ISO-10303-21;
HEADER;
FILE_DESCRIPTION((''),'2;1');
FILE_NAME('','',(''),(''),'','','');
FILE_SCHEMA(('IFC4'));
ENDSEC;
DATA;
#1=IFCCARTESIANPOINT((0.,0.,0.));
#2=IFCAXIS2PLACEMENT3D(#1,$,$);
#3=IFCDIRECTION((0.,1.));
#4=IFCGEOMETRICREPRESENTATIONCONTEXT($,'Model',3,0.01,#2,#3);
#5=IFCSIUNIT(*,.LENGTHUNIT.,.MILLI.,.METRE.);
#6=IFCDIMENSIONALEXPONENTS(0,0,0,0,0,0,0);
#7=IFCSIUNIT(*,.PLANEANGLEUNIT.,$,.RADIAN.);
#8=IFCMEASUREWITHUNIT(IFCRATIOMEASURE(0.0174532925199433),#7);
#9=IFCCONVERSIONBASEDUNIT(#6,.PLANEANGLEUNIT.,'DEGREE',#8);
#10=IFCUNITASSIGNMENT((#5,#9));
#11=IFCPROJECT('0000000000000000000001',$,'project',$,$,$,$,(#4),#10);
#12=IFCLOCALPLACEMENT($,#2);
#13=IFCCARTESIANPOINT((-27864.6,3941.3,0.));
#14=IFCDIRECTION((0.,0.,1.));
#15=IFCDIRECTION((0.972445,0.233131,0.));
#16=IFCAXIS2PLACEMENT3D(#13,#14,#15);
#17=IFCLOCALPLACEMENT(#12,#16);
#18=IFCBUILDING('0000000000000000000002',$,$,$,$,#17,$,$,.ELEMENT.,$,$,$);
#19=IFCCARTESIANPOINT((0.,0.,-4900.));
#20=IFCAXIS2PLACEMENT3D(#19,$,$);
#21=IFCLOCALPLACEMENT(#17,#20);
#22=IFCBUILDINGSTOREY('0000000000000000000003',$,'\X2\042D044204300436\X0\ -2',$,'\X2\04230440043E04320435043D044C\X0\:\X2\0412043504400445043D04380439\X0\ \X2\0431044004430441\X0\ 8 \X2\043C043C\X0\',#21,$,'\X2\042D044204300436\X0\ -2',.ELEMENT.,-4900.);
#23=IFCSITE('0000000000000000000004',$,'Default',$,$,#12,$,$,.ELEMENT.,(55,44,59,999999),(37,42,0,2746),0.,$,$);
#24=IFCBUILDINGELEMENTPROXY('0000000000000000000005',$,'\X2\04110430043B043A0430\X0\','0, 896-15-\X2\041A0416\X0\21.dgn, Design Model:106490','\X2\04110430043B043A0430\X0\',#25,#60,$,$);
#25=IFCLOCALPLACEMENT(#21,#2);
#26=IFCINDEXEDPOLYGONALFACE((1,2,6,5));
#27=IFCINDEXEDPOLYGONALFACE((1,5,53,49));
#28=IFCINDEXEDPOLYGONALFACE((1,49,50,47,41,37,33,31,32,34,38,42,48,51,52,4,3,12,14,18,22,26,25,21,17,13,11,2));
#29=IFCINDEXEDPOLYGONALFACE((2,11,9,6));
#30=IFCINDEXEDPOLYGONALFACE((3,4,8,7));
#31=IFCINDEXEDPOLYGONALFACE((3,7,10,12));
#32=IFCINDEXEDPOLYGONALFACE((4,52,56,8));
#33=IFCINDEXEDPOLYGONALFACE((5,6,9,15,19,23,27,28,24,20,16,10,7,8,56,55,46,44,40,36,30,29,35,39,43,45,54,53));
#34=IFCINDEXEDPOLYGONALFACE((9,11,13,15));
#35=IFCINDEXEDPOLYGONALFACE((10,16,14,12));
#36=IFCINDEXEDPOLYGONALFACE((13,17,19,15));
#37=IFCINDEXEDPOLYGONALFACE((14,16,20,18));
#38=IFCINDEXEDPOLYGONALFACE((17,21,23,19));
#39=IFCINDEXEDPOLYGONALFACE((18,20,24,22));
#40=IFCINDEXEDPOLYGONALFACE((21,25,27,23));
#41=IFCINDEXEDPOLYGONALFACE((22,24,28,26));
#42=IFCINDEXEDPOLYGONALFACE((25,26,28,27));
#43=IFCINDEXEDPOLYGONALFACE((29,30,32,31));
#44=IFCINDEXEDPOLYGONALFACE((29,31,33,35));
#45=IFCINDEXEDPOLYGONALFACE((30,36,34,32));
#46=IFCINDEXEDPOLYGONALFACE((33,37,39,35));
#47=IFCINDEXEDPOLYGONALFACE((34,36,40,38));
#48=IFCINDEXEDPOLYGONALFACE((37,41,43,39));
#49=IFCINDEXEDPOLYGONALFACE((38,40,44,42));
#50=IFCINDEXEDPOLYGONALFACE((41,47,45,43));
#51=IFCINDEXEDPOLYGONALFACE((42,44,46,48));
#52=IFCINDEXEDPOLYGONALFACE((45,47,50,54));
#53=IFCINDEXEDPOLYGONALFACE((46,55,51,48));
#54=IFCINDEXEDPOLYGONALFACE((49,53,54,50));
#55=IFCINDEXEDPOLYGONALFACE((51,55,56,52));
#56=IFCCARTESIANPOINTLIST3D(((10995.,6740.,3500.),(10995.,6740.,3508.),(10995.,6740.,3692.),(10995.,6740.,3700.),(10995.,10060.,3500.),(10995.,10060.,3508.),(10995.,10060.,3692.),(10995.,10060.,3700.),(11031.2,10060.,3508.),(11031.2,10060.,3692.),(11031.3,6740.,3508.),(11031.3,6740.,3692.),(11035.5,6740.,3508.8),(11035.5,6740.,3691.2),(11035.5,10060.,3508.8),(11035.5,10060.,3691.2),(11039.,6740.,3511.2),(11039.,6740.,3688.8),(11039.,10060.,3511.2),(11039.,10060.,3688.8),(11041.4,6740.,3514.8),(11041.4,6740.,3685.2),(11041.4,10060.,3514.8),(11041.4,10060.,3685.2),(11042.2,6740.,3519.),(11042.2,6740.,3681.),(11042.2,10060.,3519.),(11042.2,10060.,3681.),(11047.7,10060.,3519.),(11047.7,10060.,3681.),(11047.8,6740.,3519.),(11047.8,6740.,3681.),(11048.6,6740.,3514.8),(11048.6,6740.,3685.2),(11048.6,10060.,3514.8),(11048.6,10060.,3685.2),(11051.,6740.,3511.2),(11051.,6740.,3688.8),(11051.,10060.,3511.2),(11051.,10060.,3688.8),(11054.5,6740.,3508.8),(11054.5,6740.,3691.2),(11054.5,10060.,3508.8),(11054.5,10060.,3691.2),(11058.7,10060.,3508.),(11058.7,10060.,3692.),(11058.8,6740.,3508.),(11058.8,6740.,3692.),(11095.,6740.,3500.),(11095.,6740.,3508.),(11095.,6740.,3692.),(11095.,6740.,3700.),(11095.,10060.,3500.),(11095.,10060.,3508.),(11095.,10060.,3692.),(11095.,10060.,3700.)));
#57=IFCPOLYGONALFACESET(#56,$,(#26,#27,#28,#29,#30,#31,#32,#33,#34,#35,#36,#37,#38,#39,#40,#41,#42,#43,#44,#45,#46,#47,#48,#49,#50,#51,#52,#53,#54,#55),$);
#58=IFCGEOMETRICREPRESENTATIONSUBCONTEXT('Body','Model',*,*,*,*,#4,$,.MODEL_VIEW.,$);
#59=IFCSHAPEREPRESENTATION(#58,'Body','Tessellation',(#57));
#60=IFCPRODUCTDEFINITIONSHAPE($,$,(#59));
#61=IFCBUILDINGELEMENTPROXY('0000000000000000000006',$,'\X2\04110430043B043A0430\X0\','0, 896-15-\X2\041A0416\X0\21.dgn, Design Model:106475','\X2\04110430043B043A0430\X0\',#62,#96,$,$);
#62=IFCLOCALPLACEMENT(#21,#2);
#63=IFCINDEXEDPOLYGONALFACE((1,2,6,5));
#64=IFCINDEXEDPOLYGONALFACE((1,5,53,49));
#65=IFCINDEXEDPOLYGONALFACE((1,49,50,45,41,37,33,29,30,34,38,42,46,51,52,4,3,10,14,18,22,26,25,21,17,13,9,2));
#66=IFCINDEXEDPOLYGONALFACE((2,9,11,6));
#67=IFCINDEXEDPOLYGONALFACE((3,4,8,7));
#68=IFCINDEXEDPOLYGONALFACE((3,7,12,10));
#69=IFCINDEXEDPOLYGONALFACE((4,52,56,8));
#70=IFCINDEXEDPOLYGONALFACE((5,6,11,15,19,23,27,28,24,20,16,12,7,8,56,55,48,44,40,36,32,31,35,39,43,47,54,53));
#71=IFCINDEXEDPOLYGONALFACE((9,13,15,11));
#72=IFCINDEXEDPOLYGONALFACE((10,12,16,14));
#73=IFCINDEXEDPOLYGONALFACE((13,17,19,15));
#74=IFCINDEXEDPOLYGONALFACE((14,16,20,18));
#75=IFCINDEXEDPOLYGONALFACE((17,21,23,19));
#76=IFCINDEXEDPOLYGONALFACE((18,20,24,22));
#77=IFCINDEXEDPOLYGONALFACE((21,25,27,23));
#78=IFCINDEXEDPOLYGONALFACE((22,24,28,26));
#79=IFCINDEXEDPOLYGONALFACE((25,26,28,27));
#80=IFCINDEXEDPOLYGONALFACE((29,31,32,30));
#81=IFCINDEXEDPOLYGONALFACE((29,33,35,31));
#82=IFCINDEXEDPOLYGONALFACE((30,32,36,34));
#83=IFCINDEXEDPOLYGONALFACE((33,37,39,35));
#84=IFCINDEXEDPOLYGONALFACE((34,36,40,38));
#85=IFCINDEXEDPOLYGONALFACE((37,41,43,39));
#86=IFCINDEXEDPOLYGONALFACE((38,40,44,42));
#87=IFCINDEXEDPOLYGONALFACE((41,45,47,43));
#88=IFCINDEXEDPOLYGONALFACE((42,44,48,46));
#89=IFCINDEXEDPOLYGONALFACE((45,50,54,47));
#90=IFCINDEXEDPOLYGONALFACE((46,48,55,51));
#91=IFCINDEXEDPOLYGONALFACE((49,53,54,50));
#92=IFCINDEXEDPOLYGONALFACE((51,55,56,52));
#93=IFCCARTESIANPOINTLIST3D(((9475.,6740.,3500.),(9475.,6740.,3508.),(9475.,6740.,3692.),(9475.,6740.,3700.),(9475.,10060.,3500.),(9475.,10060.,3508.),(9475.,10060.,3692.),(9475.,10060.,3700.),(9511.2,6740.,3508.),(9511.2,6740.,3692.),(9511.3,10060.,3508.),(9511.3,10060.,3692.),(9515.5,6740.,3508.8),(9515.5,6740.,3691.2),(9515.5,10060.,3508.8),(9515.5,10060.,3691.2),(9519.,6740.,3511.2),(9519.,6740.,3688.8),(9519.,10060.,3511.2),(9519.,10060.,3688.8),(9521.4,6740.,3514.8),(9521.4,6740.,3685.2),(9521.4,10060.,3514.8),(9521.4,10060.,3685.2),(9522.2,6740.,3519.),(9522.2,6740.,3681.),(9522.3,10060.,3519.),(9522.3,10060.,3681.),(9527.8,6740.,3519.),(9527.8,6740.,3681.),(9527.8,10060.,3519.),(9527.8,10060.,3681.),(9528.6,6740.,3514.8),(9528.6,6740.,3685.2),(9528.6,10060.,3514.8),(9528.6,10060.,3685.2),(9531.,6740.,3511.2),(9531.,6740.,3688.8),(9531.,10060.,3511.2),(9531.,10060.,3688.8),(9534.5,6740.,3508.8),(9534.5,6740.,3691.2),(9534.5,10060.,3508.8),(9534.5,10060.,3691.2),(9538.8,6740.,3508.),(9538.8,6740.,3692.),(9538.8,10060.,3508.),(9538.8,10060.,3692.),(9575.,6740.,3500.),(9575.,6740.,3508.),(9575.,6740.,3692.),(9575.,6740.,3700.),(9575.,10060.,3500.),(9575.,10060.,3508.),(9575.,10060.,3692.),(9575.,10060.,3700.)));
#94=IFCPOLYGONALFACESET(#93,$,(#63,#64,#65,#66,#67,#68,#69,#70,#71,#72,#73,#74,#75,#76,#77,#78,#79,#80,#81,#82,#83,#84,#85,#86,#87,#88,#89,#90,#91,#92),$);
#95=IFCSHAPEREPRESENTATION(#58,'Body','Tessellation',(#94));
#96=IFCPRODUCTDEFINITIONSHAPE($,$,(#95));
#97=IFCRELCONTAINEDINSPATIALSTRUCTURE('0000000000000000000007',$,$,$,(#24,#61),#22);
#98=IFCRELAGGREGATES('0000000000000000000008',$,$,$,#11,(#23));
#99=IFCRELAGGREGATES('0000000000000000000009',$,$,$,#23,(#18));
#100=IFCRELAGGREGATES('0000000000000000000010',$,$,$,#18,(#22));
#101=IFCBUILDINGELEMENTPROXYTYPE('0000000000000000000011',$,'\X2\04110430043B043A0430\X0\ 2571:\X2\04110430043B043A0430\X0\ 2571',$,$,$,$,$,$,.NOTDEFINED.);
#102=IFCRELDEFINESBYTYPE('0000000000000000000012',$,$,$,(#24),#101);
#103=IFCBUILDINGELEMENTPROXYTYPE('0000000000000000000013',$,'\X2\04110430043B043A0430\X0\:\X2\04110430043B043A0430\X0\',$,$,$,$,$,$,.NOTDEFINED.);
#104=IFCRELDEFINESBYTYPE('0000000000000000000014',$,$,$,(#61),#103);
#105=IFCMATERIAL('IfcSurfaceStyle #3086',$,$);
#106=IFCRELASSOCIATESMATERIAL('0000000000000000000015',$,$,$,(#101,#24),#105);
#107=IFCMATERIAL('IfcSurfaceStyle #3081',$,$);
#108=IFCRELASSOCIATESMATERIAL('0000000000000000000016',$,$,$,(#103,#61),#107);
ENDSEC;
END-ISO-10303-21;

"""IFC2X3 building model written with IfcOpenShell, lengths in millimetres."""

from ifc_helpers import new_model, entity, si_unit, converted_unit, direction, frame, origin, place, context, subcontext, project, spatial, polyline, outline, extrude, source, transform, mapped, material, type_object, type_shapes, element, save


model = new_model("IFC2X3")

# Units and contexts
model_context = context("Model", 3, precision=0.01, world=origin(), true_north=direction((0.0, 1.0)))
body_context = subcontext(model_context, "Body", "Model", "MODEL_VIEW")
ifc_project = project(units=[si_unit("LENGTHUNIT", "METRE", prefix="MILLI"), converted_unit("PLANEANGLEUNIT", "DEGREE", entity("IfcRatioMeasure", 0.0174532925199433), si_unit("PLANEANGLEUNIT", "RADIAN"), dimensions=[0, 0, 0, 0, 0, 0, 0])], contexts=[model_context])

# Site, building, storey
site_placement = place(None, origin())
site = spatial("IfcSite", under=ifc_project, at=site_placement, Name="Default", CompositionType="ELEMENT", RefLatitude=(55, 44, 59, 999999), RefLongitude=(37, 42, 0, 2746), RefElevation=0.0)
building_placement = place(site_placement, frame((-27864.6, 3941.3, 0.0), z_axis=(0.0, 0.0, 1.0), x_axis=(0.972445, 0.233131, 0.0)))
building = spatial("IfcBuilding", under=site, at=building_placement, CompositionType="ELEMENT")
storey_placement = place(building_placement, frame((0.0, 0.0, -4900.0)))
storey = spatial("IfcBuildingStorey", under=building, at=storey_placement, Name="Этаж -2", ObjectType="Уровень:Верхний брус 8 мм", LongName="Этаж -2", CompositionType="ELEMENT", Elevation=-4900.0)

# Building element proxies
ifc_material_1 = material(Name="IfcSurfaceStyle #3086")
building_element_proxy_type_1 = type_object("IfcBuildingElementProxyType", Name="Балка 2571:Балка 2571", PredefinedType="NOTDEFINED", material=ifc_material_1)
shared_shape_1 = source(origin(), body_context, "Body", "SweptSolid", [
    extrude(outline(polyline([(92.0, -50.0), (100.0, -50.0), (100.0, 50.0), (92.0, 50.0), (92.0, 13.7), (91.2, 9.5), (88.8, 6.0), (85.2, 3.6), (81.0, 2.7), (-81.0, 2.7), (-85.2, 3.6), (-88.8, 6.0), (-91.2, 9.5), (-92.0, 13.7), (-92.0, 50.0), (-100.0, 50.0), (-100.0, -50.0), (-92.0, -50.0), (-92.0, -13.8), (-91.2, -9.5), (-88.8, -6.0), (-85.2, -3.6), (-81.0, -2.8), (81.0, -2.8), (85.2, -3.6), (88.8, -6.0), (91.2, -9.5), (92.0, -13.8), (92.0, -50.0)])), frame((11045.0, 6740.0, -1300.0), z_axis=(0.0, 1.0, 0.0), x_axis=(0.0, 0.0, -1.0)), (0.0, 0.0, 1.0), 3320.0),
])
type_shapes(building_element_proxy_type_1, [shared_shape_1])
proxy_1_placement = place(storey_placement, frame((0.0, 0.0, 4900.0)))
element("IfcBuildingElementProxy", 1, at=proxy_1_placement, inside=storey, type_object=building_element_proxy_type_1, material=ifc_material_1, Name="Балка", Description="0, 896-15-КЖ21.dgn, Design Model:106490", ObjectType="Балка", context=body_context, shape_type="MappedRepresentation", body=[
    mapped(shared_shape_1, transform((0.0, 0.0, 0.0), scale=1.0)),
])
ifc_material_2 = material(Name="IfcSurfaceStyle #3081")
building_element_proxy_type_2 = type_object("IfcBuildingElementProxyType", Name="Балка:Балка", PredefinedType="NOTDEFINED", material=ifc_material_2)
shared_shape_2 = source(origin(), body_context, "Body", "SweptSolid", [
    extrude(outline(polyline([(92.0, -50.0), (100.0, -50.0), (100.0, 50.0), (92.0, 50.0), (92.0, 13.7), (91.2, 9.5), (88.8, 6.0), (85.2, 3.6), (81.0, 2.7), (-81.0, 2.7), (-85.2, 3.6), (-88.8, 6.0), (-91.2, 9.5), (-92.0, 13.7), (-92.0, 50.0), (-100.0, 50.0), (-100.0, -50.0), (-92.0, -50.0), (-92.0, -13.8), (-91.2, -9.5), (-88.8, -6.0), (-85.2, -3.6), (-81.0, -2.8), (81.0, -2.8), (85.2, -3.6), (88.8, -6.0), (91.2, -9.5), (92.0, -13.8), (92.0, -50.0)])), frame((9525.0, 6740.0, -1300.0), z_axis=(0.0, 1.0, 0.0), x_axis=(0.0, 0.0, -1.0)), (0.0, 0.0, 1.0), 3320.0),
])
type_shapes(building_element_proxy_type_2, [shared_shape_2])
proxy_2_placement = place(storey_placement, frame((0.0, 0.0, 4900.0)))
element("IfcBuildingElementProxy", 2, at=proxy_2_placement, inside=storey, type_object=building_element_proxy_type_2, material=ifc_material_2, Name="Балка", Description="0, 896-15-КЖ21.dgn, Design Model:106475", ObjectType="Балка", context=body_context, shape_type="MappedRepresentation", body=[
    mapped(shared_shape_2, transform((0.0, 0.0, 0.0), scale=1.0)),
])

save(model, "model.ifc")
